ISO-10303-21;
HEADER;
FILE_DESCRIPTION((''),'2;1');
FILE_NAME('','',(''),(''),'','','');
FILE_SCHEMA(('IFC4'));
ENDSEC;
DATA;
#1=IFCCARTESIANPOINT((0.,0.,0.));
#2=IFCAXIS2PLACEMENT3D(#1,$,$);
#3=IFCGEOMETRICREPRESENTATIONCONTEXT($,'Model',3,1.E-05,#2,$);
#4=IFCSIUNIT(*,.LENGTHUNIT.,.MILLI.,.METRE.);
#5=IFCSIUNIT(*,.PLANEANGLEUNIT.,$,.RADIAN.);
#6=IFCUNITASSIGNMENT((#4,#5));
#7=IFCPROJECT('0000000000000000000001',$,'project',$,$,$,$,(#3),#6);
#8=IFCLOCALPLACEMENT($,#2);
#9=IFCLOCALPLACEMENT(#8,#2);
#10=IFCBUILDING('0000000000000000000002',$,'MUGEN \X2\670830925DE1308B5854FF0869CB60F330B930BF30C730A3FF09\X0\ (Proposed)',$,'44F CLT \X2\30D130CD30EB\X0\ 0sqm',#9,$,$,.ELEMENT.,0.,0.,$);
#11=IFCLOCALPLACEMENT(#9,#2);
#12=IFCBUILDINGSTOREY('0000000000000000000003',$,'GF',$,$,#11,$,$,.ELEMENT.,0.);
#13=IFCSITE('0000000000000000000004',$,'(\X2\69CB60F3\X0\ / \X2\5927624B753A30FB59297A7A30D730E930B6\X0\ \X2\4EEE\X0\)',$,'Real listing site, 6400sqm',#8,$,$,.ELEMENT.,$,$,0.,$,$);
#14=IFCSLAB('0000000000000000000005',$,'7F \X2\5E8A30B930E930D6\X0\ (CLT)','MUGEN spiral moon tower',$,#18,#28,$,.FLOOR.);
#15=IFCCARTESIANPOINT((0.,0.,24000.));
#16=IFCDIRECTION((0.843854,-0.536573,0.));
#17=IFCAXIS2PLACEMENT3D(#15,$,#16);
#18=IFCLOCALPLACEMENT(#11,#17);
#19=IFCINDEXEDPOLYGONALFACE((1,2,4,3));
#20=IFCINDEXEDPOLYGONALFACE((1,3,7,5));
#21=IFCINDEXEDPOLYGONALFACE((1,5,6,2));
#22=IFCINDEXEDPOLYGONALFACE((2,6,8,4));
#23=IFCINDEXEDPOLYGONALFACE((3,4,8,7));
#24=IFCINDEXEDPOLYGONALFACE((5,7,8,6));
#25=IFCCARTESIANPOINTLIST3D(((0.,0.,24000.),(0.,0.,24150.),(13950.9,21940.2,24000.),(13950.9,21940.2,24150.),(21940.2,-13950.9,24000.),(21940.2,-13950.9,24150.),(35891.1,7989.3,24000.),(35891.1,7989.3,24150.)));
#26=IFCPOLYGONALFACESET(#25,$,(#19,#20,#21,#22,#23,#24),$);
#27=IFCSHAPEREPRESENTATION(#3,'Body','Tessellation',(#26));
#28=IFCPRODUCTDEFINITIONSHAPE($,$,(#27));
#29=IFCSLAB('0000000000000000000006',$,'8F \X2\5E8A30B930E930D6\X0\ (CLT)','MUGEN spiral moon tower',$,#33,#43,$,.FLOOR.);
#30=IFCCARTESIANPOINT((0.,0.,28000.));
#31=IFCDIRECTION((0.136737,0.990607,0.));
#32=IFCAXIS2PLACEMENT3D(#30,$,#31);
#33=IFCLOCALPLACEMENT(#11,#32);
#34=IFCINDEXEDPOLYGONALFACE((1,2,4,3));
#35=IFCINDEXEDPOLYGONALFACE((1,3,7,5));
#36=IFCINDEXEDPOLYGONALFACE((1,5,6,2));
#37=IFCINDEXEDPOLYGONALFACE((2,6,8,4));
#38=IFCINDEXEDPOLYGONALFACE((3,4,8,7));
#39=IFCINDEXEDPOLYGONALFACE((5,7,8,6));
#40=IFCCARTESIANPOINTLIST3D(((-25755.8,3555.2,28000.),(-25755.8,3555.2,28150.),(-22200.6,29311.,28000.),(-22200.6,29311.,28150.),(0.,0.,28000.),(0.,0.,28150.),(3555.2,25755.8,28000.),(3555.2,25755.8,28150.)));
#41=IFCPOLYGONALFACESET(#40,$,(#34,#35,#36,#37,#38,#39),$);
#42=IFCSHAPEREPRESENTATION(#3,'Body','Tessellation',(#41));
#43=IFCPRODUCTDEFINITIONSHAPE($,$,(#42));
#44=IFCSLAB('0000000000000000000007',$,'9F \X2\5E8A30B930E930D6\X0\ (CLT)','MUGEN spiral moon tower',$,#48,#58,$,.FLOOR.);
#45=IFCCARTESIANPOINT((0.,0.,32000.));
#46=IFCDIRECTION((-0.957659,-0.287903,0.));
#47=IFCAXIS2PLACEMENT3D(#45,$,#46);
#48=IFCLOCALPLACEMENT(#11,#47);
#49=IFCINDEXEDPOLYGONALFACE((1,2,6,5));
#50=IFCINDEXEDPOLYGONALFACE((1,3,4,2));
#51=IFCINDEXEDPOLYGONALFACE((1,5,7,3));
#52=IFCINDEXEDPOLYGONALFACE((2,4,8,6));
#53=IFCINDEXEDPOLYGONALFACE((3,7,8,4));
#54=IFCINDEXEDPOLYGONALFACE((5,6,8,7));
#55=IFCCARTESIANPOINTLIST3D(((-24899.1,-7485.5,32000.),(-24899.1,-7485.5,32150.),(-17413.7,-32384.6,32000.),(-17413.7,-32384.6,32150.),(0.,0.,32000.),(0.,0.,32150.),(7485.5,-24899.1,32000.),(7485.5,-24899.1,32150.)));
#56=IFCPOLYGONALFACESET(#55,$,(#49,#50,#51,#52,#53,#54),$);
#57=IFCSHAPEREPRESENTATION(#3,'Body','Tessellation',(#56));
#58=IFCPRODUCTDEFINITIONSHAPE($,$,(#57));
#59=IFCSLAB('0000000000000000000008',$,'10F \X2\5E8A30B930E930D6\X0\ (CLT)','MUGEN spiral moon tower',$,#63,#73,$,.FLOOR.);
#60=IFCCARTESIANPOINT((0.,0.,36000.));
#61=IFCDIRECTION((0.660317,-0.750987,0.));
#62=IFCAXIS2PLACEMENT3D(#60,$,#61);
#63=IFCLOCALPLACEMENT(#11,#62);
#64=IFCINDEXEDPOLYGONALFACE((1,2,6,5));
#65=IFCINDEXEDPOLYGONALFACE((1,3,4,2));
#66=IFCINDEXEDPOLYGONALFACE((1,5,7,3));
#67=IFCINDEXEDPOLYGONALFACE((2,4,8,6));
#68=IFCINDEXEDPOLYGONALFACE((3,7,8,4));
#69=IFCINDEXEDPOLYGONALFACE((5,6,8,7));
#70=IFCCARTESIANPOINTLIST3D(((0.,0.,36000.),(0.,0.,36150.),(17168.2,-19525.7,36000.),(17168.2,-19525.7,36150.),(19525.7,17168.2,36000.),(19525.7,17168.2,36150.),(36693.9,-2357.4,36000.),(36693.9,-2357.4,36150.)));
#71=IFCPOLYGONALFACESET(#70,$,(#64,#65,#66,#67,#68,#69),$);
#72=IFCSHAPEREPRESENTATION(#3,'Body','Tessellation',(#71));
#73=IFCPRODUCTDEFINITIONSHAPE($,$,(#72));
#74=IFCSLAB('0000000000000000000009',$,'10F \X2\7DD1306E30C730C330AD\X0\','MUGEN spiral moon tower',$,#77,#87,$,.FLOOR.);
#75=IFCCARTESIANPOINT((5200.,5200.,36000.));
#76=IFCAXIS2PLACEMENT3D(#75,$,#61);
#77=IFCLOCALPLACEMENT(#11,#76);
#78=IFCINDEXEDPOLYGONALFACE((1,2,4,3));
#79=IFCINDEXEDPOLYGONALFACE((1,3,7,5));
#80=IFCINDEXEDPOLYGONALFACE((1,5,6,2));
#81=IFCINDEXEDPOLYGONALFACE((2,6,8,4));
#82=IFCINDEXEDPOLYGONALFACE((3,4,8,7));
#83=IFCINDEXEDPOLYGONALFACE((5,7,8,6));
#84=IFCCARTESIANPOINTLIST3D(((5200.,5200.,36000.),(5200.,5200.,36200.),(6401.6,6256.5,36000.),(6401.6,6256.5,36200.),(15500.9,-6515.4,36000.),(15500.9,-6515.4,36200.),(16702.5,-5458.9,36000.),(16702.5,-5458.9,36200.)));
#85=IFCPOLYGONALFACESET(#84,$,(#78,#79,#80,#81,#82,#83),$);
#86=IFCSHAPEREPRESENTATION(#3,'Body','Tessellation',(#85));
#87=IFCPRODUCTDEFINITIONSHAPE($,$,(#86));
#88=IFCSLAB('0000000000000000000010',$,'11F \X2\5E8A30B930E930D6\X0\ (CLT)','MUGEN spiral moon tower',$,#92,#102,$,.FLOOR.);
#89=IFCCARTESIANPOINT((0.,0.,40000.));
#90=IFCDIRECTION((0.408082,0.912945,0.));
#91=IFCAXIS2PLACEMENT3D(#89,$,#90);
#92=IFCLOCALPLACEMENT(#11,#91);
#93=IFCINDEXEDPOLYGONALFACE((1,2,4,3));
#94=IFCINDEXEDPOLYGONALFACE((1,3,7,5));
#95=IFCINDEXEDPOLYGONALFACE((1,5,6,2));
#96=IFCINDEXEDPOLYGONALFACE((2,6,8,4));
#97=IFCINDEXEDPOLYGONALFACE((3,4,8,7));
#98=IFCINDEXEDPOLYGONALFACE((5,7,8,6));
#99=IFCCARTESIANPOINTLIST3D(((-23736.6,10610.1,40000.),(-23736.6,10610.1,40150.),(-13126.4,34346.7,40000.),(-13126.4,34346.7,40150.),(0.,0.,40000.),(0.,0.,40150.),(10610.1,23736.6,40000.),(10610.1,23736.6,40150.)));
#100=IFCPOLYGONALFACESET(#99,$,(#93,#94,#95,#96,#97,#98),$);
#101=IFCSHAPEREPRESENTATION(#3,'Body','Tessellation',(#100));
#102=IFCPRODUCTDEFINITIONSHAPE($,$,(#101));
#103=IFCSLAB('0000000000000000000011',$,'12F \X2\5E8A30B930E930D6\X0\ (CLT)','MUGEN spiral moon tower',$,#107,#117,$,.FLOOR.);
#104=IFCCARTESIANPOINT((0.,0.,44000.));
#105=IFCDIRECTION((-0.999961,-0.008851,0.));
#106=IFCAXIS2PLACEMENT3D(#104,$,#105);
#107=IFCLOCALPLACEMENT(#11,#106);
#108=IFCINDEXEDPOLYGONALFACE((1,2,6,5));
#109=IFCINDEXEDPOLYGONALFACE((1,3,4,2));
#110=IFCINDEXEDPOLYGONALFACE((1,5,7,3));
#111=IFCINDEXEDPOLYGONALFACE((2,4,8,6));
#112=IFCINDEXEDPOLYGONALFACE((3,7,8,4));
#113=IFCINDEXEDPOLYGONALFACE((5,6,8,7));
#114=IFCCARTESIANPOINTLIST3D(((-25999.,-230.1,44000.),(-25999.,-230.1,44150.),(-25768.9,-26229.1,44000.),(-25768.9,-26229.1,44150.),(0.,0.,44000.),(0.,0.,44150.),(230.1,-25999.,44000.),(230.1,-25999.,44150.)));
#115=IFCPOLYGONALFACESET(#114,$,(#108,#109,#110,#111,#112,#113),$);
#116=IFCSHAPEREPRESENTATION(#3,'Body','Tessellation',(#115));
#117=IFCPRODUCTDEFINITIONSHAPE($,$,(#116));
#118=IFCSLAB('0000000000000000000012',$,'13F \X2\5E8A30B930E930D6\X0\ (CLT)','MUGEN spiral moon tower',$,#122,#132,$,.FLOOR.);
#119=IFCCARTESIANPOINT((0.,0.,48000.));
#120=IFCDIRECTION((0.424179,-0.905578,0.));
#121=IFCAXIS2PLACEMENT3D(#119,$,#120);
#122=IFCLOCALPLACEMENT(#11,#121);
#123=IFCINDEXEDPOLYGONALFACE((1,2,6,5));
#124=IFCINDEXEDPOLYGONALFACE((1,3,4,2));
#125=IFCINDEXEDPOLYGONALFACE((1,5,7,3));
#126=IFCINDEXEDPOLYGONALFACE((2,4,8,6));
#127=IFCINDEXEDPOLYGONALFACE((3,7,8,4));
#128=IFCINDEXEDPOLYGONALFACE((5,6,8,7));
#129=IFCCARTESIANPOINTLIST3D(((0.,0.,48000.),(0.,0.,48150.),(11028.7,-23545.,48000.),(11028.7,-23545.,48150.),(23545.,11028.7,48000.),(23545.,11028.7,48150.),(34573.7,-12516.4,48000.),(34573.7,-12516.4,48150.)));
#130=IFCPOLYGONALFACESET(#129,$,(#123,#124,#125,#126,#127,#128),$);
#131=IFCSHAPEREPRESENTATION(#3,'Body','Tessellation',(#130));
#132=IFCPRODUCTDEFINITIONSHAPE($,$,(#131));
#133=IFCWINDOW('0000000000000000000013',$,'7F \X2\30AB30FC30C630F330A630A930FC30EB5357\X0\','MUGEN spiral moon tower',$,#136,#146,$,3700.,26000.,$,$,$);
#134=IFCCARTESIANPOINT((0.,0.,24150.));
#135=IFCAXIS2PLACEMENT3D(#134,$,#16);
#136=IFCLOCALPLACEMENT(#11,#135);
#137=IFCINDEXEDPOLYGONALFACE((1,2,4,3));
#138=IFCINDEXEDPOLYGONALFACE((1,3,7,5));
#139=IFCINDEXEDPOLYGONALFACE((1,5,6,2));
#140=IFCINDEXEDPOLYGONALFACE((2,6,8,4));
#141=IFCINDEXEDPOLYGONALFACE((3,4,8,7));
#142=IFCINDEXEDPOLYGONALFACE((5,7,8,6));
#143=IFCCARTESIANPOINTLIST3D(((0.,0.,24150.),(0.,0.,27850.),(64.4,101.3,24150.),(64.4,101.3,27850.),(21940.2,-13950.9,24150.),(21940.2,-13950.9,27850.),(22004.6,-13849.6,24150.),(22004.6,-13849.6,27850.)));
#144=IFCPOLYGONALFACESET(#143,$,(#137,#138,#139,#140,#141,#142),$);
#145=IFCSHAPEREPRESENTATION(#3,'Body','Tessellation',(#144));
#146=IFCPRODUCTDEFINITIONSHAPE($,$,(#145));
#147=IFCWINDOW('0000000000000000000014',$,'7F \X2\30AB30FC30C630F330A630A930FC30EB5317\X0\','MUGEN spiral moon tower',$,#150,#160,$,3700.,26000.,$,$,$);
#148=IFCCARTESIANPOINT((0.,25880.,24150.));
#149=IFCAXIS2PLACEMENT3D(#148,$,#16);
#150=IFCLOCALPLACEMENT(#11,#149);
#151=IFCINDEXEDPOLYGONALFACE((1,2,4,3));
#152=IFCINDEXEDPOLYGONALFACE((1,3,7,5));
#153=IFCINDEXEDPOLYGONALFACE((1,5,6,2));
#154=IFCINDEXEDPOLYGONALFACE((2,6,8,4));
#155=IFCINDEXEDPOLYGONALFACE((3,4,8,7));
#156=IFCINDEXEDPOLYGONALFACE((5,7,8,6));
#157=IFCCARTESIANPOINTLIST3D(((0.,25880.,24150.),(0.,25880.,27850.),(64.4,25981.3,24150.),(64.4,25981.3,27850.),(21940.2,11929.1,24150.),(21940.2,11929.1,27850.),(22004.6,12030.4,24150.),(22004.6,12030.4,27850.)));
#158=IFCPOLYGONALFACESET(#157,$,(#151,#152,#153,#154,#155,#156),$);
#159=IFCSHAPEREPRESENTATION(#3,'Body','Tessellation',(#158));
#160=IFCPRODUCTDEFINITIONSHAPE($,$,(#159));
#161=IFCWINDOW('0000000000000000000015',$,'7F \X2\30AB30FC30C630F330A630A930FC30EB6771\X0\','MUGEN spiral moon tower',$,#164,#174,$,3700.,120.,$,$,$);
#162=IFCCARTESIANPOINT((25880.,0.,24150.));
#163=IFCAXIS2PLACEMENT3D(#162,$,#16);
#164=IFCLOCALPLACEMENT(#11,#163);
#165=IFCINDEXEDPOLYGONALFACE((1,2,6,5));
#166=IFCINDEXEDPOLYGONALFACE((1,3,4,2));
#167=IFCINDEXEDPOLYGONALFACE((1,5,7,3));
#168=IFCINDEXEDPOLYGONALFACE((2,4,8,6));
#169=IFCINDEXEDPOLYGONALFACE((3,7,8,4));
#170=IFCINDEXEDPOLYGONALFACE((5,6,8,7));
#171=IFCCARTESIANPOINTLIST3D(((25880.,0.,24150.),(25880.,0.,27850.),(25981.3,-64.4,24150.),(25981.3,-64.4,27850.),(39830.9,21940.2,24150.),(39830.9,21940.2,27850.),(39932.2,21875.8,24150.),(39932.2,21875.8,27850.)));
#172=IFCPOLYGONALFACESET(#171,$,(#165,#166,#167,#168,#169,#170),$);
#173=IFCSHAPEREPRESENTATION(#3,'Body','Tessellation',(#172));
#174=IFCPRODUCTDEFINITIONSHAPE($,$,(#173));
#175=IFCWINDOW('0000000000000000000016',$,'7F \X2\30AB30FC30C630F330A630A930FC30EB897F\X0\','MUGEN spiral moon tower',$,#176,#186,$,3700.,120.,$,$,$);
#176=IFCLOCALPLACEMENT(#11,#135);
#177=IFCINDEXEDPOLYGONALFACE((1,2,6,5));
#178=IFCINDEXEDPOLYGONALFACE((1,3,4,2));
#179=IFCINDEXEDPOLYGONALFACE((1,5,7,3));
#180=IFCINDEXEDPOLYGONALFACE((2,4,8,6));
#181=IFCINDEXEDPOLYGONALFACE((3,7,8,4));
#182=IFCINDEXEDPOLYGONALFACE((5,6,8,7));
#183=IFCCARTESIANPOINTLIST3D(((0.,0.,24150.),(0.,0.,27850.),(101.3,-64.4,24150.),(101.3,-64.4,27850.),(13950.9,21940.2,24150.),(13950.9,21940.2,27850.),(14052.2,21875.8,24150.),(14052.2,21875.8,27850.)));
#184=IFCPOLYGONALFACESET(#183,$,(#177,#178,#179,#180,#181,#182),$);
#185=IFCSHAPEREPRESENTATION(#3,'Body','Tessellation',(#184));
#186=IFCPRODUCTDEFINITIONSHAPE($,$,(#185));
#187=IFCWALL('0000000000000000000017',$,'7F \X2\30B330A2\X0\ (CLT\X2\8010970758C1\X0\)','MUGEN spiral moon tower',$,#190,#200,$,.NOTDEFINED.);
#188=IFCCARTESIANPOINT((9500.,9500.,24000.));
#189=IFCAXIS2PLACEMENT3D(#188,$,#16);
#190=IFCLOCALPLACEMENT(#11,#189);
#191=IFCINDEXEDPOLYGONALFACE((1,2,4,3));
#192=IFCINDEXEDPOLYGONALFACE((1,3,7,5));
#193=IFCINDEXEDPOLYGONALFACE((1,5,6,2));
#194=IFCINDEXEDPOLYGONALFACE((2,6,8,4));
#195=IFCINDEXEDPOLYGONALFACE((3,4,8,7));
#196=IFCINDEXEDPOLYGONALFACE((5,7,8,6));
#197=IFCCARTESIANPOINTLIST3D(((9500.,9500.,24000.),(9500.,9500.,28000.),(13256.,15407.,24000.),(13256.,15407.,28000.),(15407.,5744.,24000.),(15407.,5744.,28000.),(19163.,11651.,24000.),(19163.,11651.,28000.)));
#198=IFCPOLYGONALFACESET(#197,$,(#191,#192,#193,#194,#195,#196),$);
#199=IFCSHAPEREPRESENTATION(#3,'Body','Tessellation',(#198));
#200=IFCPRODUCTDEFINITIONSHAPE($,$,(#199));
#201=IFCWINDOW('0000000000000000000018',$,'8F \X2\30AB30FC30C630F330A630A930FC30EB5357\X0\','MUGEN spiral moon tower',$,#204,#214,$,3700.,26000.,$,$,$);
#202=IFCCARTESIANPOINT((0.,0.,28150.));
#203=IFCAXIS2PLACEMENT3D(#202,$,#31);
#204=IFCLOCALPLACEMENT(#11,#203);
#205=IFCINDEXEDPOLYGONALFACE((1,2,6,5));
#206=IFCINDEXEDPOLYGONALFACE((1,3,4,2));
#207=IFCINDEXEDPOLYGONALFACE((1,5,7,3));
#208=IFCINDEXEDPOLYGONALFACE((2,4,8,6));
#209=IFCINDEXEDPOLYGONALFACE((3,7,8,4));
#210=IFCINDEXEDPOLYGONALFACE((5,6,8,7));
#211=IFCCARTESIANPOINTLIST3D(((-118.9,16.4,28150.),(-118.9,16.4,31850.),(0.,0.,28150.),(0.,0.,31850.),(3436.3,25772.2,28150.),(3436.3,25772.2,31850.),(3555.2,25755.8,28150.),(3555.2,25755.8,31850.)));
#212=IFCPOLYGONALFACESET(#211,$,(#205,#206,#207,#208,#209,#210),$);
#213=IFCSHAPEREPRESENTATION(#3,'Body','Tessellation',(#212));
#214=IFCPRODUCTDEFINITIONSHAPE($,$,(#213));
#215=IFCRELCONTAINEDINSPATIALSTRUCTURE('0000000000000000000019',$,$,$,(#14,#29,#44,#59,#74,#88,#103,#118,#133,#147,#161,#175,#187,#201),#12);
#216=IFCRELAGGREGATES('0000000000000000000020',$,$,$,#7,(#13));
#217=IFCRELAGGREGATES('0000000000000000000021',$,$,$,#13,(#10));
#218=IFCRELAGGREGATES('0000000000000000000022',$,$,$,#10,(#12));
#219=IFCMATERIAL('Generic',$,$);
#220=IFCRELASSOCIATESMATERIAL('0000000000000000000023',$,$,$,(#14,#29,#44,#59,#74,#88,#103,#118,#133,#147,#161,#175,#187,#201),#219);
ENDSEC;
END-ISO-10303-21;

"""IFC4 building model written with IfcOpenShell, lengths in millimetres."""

from ifc_helpers import new_model, si_unit, frame, frame_2d, origin, place, context, project, spatial, rectangle, extrude, material, element, save


model = new_model("IFC4")

# Units and contexts
model_context = context("Model", 3, precision=1e-05, world=origin())
ifc_project = project(units=[si_unit("LENGTHUNIT", "METRE", prefix="MILLI"), si_unit("PLANEANGLEUNIT", "RADIAN")], contexts=[model_context])

# Site, building, storey
site_placement = place(None, origin())
site = spatial("IfcSite", under=ifc_project, at=site_placement, Name="(構想 / 大手町・天空プラザ 仮)", ObjectType="Real listing site, 6400sqm", CompositionType="ELEMENT", RefElevation=0.0)
building_placement = place(site_placement, origin())
building = spatial("IfcBuilding", under=site, at=building_placement, Name="MUGEN 月を巡る塔（構想スタディ） (Proposed)", ObjectType="44F CLT パネル 0sqm", CompositionType="ELEMENT", ElevationOfRefHeight=0.0, ElevationOfTerrain=0.0)
storey_placement = place(building_placement, origin())
storey = spatial("IfcBuildingStorey", under=building, at=storey_placement, Name="GF", CompositionType="ELEMENT", Elevation=0.0)

# Slabs
ifc_material = material(Name="Generic")
slab_1_placement = place(storey_placement, frame((0.0, 0.0, 24000.0), x_axis=(0.843854, -0.536573, 0.0)))
element("IfcSlab", 1, at=slab_1_placement, inside=storey, material=ifc_material, Name="7F 床スラブ (CLT)", Description="MUGEN spiral moon tower", PredefinedType="FLOOR", context=model_context, shape_type="SweptSolid", body=[
    extrude(rectangle(XDim=26000.0, YDim=26000.0, at=frame_2d((13000.0, 13000.0))), frame((0.0, 0.0, 24000.0), x_axis=(0.843854, -0.536573, 0.0)), (0.0, 0.0, 1.0), 150.0),
])
slab_2_placement = place(storey_placement, frame((0.0, 0.0, 28000.0), x_axis=(0.136737, 0.990607, 0.0)))
element("IfcSlab", 2, at=slab_2_placement, inside=storey, material=ifc_material, Name="8F 床スラブ (CLT)", Description="MUGEN spiral moon tower", PredefinedType="FLOOR", context=model_context, shape_type="SweptSolid", body=[
    extrude(rectangle(XDim=26000.0, YDim=26000.0, at=frame_2d((13000.0, 13000.0))), frame((0.0, 0.0, 28000.0), x_axis=(0.136737, 0.990607, 0.0)), (0.0, 0.0, 1.0), 150.0),
])
slab_3_placement = place(storey_placement, frame((0.0, 0.0, 32000.0), x_axis=(-0.957659, -0.287903, 0.0)))
element("IfcSlab", 3, at=slab_3_placement, inside=storey, material=ifc_material, Name="9F 床スラブ (CLT)", Description="MUGEN spiral moon tower", PredefinedType="FLOOR", context=model_context, shape_type="SweptSolid", body=[
    extrude(rectangle(XDim=26000.0, YDim=26000.0, at=frame_2d((13000.0, 13000.0))), frame((0.0, 0.0, 32000.0), x_axis=(-0.957659, -0.287903, 0.0)), (0.0, 0.0, 1.0), 150.0),
])
slab_4_placement = place(storey_placement, frame((0.0, 0.0, 36000.0), x_axis=(0.660317, -0.750987, 0.0)))
element("IfcSlab", 4, at=slab_4_placement, inside=storey, material=ifc_material, Name="10F 床スラブ (CLT)", Description="MUGEN spiral moon tower", PredefinedType="FLOOR", context=model_context, shape_type="SweptSolid", body=[
    extrude(rectangle(XDim=26000.0, YDim=26000.0, at=frame_2d((13000.0, 13000.0))), frame((0.0, 0.0, 36000.0), x_axis=(0.660317, -0.750987, 0.0)), (0.0, 0.0, 1.0), 150.0),
])
slab_5_placement = place(storey_placement, frame((5200.0, 5200.0, 36000.0), x_axis=(0.660317, -0.750987, 0.0)))
element("IfcSlab", 5, at=slab_5_placement, inside=storey, material=ifc_material, Name="10F 緑のデッキ", Description="MUGEN spiral moon tower", PredefinedType="FLOOR", context=model_context, shape_type="SweptSolid", body=[
    extrude(rectangle(XDim=15600.0, YDim=1600.0, at=frame_2d((7800.0, 800.0))), frame((5200.0, 5200.0, 36000.0), x_axis=(0.660317, -0.750987, 0.0)), (0.0, 0.0, 1.0), 200.0),
])
slab_6_placement = place(storey_placement, frame((0.0, 0.0, 40000.0), x_axis=(0.408082, 0.912945, 0.0)))
element("IfcSlab", 6, at=slab_6_placement, inside=storey, material=ifc_material, Name="11F 床スラブ (CLT)", Description="MUGEN spiral moon tower", PredefinedType="FLOOR", context=model_context, shape_type="SweptSolid", body=[
    extrude(rectangle(XDim=26000.0, YDim=26000.0, at=frame_2d((13000.0, 13000.0))), frame((0.0, 0.0, 40000.0), x_axis=(0.408082, 0.912945, 0.0)), (0.0, 0.0, 1.0), 150.0),
])
slab_7_placement = place(storey_placement, frame((0.0, 0.0, 44000.0), x_axis=(-0.999961, -0.008851, 0.0)))
element("IfcSlab", 7, at=slab_7_placement, inside=storey, material=ifc_material, Name="12F 床スラブ (CLT)", Description="MUGEN spiral moon tower", PredefinedType="FLOOR", context=model_context, shape_type="SweptSolid", body=[
    extrude(rectangle(XDim=26000.0, YDim=26000.0, at=frame_2d((13000.0, 13000.0))), frame((0.0, 0.0, 44000.0), x_axis=(-0.999961, -0.008851, 0.0)), (0.0, 0.0, 1.0), 150.0),
])
slab_8_placement = place(storey_placement, frame((0.0, 0.0, 48000.0), x_axis=(0.424179, -0.905578, 0.0)))
element("IfcSlab", 8, at=slab_8_placement, inside=storey, material=ifc_material, Name="13F 床スラブ (CLT)", Description="MUGEN spiral moon tower", PredefinedType="FLOOR", context=model_context, shape_type="SweptSolid", body=[
    extrude(rectangle(XDim=26000.0, YDim=26000.0, at=frame_2d((13000.0, 13000.0))), frame((0.0, 0.0, 48000.0), x_axis=(0.424179, -0.905578, 0.0)), (0.0, 0.0, 1.0), 150.0),
])

# Windows
window_1_placement = place(storey_placement, frame((0.0, 0.0, 24150.0), x_axis=(0.843854, -0.536573, 0.0)))
element("IfcWindow", 9, at=window_1_placement, inside=storey, material=ifc_material, Name="7F カーテンウォール南", Description="MUGEN spiral moon tower", OverallHeight=3700.0, OverallWidth=26000.0, context=model_context, shape_type="SweptSolid", body=[
    extrude(rectangle(XDim=26000.0, YDim=120.0, at=frame_2d((13000.0, 60.0))), frame((0.0, 0.0, 24150.0), x_axis=(0.843854, -0.536573, 0.0)), (0.0, 0.0, 1.0), 3700.0),
])
window_2_placement = place(storey_placement, frame((0.0, 25880.0, 24150.0), x_axis=(0.843854, -0.536573, 0.0)))
element("IfcWindow", 10, at=window_2_placement, inside=storey, material=ifc_material, Name="7F カーテンウォール北", Description="MUGEN spiral moon tower", OverallHeight=3700.0, OverallWidth=26000.0, context=model_context, shape_type="SweptSolid", body=[
    extrude(rectangle(XDim=26000.0, YDim=120.0, at=frame_2d((13000.0, 60.0))), frame((0.0, 25880.0, 24150.0), x_axis=(0.843854, -0.536573, 0.0)), (0.0, 0.0, 1.0), 3700.0),
])
window_3_placement = place(storey_placement, frame((25880.0, 0.0, 24150.0), x_axis=(0.843854, -0.536573, 0.0)))
element("IfcWindow", 11, at=window_3_placement, inside=storey, material=ifc_material, Name="7F カーテンウォール東", Description="MUGEN spiral moon tower", OverallHeight=3700.0, OverallWidth=120.0, context=model_context, shape_type="SweptSolid", body=[
    extrude(rectangle(XDim=120.0, YDim=26000.0, at=frame_2d((60.0, 13000.0))), frame((25880.0, 0.0, 24150.0), x_axis=(0.843854, -0.536573, 0.0)), (0.0, 0.0, 1.0), 3700.0),
])
window_4_placement = place(storey_placement, frame((0.0, 0.0, 24150.0), x_axis=(0.843854, -0.536573, 0.0)))
element("IfcWindow", 12, at=window_4_placement, inside=storey, material=ifc_material, Name="7F カーテンウォール西", Description="MUGEN spiral moon tower", OverallHeight=3700.0, OverallWidth=120.0, context=model_context, shape_type="SweptSolid", body=[
    extrude(rectangle(XDim=120.0, YDim=26000.0, at=frame_2d((60.0, 13000.0))), frame((0.0, 0.0, 24150.0), x_axis=(0.843854, -0.536573, 0.0)), (0.0, 0.0, 1.0), 3700.0),
])

# Wall
wall_1_placement = place(storey_placement, frame((9500.0, 9500.0, 24000.0), x_axis=(0.843854, -0.536573, 0.0)))
element("IfcWall", 13, at=wall_1_placement, inside=storey, material=ifc_material, Name="7F コア (CLT耐震壁)", Description="MUGEN spiral moon tower", PredefinedType="NOTDEFINED", context=model_context, shape_type="SweptSolid", body=[
    extrude(rectangle(XDim=7000.0, YDim=7000.0, at=frame_2d((3500.0, 3500.0))), frame((9500.0, 9500.0, 24000.0), x_axis=(0.843854, -0.536573, 0.0)), (0.0, 0.0, 1.0), 4000.0),
])

# Window
window_5_placement = place(storey_placement, frame((0.0, 0.0, 28150.0), x_axis=(0.136737, 0.990607, 0.0)))
element("IfcWindow", 14, at=window_5_placement, inside=storey, material=ifc_material, Name="8F カーテンウォール南", Description="MUGEN spiral moon tower", OverallHeight=3700.0, OverallWidth=26000.0, context=model_context, shape_type="SweptSolid", body=[
    extrude(rectangle(XDim=26000.0, YDim=120.0, at=frame_2d((13000.0, 60.0))), frame((0.0, 0.0, 28150.0), x_axis=(0.136737, 0.990607, 0.0)), (0.0, 0.0, 1.0), 3700.0),
])

save(model, "model.ifc")
